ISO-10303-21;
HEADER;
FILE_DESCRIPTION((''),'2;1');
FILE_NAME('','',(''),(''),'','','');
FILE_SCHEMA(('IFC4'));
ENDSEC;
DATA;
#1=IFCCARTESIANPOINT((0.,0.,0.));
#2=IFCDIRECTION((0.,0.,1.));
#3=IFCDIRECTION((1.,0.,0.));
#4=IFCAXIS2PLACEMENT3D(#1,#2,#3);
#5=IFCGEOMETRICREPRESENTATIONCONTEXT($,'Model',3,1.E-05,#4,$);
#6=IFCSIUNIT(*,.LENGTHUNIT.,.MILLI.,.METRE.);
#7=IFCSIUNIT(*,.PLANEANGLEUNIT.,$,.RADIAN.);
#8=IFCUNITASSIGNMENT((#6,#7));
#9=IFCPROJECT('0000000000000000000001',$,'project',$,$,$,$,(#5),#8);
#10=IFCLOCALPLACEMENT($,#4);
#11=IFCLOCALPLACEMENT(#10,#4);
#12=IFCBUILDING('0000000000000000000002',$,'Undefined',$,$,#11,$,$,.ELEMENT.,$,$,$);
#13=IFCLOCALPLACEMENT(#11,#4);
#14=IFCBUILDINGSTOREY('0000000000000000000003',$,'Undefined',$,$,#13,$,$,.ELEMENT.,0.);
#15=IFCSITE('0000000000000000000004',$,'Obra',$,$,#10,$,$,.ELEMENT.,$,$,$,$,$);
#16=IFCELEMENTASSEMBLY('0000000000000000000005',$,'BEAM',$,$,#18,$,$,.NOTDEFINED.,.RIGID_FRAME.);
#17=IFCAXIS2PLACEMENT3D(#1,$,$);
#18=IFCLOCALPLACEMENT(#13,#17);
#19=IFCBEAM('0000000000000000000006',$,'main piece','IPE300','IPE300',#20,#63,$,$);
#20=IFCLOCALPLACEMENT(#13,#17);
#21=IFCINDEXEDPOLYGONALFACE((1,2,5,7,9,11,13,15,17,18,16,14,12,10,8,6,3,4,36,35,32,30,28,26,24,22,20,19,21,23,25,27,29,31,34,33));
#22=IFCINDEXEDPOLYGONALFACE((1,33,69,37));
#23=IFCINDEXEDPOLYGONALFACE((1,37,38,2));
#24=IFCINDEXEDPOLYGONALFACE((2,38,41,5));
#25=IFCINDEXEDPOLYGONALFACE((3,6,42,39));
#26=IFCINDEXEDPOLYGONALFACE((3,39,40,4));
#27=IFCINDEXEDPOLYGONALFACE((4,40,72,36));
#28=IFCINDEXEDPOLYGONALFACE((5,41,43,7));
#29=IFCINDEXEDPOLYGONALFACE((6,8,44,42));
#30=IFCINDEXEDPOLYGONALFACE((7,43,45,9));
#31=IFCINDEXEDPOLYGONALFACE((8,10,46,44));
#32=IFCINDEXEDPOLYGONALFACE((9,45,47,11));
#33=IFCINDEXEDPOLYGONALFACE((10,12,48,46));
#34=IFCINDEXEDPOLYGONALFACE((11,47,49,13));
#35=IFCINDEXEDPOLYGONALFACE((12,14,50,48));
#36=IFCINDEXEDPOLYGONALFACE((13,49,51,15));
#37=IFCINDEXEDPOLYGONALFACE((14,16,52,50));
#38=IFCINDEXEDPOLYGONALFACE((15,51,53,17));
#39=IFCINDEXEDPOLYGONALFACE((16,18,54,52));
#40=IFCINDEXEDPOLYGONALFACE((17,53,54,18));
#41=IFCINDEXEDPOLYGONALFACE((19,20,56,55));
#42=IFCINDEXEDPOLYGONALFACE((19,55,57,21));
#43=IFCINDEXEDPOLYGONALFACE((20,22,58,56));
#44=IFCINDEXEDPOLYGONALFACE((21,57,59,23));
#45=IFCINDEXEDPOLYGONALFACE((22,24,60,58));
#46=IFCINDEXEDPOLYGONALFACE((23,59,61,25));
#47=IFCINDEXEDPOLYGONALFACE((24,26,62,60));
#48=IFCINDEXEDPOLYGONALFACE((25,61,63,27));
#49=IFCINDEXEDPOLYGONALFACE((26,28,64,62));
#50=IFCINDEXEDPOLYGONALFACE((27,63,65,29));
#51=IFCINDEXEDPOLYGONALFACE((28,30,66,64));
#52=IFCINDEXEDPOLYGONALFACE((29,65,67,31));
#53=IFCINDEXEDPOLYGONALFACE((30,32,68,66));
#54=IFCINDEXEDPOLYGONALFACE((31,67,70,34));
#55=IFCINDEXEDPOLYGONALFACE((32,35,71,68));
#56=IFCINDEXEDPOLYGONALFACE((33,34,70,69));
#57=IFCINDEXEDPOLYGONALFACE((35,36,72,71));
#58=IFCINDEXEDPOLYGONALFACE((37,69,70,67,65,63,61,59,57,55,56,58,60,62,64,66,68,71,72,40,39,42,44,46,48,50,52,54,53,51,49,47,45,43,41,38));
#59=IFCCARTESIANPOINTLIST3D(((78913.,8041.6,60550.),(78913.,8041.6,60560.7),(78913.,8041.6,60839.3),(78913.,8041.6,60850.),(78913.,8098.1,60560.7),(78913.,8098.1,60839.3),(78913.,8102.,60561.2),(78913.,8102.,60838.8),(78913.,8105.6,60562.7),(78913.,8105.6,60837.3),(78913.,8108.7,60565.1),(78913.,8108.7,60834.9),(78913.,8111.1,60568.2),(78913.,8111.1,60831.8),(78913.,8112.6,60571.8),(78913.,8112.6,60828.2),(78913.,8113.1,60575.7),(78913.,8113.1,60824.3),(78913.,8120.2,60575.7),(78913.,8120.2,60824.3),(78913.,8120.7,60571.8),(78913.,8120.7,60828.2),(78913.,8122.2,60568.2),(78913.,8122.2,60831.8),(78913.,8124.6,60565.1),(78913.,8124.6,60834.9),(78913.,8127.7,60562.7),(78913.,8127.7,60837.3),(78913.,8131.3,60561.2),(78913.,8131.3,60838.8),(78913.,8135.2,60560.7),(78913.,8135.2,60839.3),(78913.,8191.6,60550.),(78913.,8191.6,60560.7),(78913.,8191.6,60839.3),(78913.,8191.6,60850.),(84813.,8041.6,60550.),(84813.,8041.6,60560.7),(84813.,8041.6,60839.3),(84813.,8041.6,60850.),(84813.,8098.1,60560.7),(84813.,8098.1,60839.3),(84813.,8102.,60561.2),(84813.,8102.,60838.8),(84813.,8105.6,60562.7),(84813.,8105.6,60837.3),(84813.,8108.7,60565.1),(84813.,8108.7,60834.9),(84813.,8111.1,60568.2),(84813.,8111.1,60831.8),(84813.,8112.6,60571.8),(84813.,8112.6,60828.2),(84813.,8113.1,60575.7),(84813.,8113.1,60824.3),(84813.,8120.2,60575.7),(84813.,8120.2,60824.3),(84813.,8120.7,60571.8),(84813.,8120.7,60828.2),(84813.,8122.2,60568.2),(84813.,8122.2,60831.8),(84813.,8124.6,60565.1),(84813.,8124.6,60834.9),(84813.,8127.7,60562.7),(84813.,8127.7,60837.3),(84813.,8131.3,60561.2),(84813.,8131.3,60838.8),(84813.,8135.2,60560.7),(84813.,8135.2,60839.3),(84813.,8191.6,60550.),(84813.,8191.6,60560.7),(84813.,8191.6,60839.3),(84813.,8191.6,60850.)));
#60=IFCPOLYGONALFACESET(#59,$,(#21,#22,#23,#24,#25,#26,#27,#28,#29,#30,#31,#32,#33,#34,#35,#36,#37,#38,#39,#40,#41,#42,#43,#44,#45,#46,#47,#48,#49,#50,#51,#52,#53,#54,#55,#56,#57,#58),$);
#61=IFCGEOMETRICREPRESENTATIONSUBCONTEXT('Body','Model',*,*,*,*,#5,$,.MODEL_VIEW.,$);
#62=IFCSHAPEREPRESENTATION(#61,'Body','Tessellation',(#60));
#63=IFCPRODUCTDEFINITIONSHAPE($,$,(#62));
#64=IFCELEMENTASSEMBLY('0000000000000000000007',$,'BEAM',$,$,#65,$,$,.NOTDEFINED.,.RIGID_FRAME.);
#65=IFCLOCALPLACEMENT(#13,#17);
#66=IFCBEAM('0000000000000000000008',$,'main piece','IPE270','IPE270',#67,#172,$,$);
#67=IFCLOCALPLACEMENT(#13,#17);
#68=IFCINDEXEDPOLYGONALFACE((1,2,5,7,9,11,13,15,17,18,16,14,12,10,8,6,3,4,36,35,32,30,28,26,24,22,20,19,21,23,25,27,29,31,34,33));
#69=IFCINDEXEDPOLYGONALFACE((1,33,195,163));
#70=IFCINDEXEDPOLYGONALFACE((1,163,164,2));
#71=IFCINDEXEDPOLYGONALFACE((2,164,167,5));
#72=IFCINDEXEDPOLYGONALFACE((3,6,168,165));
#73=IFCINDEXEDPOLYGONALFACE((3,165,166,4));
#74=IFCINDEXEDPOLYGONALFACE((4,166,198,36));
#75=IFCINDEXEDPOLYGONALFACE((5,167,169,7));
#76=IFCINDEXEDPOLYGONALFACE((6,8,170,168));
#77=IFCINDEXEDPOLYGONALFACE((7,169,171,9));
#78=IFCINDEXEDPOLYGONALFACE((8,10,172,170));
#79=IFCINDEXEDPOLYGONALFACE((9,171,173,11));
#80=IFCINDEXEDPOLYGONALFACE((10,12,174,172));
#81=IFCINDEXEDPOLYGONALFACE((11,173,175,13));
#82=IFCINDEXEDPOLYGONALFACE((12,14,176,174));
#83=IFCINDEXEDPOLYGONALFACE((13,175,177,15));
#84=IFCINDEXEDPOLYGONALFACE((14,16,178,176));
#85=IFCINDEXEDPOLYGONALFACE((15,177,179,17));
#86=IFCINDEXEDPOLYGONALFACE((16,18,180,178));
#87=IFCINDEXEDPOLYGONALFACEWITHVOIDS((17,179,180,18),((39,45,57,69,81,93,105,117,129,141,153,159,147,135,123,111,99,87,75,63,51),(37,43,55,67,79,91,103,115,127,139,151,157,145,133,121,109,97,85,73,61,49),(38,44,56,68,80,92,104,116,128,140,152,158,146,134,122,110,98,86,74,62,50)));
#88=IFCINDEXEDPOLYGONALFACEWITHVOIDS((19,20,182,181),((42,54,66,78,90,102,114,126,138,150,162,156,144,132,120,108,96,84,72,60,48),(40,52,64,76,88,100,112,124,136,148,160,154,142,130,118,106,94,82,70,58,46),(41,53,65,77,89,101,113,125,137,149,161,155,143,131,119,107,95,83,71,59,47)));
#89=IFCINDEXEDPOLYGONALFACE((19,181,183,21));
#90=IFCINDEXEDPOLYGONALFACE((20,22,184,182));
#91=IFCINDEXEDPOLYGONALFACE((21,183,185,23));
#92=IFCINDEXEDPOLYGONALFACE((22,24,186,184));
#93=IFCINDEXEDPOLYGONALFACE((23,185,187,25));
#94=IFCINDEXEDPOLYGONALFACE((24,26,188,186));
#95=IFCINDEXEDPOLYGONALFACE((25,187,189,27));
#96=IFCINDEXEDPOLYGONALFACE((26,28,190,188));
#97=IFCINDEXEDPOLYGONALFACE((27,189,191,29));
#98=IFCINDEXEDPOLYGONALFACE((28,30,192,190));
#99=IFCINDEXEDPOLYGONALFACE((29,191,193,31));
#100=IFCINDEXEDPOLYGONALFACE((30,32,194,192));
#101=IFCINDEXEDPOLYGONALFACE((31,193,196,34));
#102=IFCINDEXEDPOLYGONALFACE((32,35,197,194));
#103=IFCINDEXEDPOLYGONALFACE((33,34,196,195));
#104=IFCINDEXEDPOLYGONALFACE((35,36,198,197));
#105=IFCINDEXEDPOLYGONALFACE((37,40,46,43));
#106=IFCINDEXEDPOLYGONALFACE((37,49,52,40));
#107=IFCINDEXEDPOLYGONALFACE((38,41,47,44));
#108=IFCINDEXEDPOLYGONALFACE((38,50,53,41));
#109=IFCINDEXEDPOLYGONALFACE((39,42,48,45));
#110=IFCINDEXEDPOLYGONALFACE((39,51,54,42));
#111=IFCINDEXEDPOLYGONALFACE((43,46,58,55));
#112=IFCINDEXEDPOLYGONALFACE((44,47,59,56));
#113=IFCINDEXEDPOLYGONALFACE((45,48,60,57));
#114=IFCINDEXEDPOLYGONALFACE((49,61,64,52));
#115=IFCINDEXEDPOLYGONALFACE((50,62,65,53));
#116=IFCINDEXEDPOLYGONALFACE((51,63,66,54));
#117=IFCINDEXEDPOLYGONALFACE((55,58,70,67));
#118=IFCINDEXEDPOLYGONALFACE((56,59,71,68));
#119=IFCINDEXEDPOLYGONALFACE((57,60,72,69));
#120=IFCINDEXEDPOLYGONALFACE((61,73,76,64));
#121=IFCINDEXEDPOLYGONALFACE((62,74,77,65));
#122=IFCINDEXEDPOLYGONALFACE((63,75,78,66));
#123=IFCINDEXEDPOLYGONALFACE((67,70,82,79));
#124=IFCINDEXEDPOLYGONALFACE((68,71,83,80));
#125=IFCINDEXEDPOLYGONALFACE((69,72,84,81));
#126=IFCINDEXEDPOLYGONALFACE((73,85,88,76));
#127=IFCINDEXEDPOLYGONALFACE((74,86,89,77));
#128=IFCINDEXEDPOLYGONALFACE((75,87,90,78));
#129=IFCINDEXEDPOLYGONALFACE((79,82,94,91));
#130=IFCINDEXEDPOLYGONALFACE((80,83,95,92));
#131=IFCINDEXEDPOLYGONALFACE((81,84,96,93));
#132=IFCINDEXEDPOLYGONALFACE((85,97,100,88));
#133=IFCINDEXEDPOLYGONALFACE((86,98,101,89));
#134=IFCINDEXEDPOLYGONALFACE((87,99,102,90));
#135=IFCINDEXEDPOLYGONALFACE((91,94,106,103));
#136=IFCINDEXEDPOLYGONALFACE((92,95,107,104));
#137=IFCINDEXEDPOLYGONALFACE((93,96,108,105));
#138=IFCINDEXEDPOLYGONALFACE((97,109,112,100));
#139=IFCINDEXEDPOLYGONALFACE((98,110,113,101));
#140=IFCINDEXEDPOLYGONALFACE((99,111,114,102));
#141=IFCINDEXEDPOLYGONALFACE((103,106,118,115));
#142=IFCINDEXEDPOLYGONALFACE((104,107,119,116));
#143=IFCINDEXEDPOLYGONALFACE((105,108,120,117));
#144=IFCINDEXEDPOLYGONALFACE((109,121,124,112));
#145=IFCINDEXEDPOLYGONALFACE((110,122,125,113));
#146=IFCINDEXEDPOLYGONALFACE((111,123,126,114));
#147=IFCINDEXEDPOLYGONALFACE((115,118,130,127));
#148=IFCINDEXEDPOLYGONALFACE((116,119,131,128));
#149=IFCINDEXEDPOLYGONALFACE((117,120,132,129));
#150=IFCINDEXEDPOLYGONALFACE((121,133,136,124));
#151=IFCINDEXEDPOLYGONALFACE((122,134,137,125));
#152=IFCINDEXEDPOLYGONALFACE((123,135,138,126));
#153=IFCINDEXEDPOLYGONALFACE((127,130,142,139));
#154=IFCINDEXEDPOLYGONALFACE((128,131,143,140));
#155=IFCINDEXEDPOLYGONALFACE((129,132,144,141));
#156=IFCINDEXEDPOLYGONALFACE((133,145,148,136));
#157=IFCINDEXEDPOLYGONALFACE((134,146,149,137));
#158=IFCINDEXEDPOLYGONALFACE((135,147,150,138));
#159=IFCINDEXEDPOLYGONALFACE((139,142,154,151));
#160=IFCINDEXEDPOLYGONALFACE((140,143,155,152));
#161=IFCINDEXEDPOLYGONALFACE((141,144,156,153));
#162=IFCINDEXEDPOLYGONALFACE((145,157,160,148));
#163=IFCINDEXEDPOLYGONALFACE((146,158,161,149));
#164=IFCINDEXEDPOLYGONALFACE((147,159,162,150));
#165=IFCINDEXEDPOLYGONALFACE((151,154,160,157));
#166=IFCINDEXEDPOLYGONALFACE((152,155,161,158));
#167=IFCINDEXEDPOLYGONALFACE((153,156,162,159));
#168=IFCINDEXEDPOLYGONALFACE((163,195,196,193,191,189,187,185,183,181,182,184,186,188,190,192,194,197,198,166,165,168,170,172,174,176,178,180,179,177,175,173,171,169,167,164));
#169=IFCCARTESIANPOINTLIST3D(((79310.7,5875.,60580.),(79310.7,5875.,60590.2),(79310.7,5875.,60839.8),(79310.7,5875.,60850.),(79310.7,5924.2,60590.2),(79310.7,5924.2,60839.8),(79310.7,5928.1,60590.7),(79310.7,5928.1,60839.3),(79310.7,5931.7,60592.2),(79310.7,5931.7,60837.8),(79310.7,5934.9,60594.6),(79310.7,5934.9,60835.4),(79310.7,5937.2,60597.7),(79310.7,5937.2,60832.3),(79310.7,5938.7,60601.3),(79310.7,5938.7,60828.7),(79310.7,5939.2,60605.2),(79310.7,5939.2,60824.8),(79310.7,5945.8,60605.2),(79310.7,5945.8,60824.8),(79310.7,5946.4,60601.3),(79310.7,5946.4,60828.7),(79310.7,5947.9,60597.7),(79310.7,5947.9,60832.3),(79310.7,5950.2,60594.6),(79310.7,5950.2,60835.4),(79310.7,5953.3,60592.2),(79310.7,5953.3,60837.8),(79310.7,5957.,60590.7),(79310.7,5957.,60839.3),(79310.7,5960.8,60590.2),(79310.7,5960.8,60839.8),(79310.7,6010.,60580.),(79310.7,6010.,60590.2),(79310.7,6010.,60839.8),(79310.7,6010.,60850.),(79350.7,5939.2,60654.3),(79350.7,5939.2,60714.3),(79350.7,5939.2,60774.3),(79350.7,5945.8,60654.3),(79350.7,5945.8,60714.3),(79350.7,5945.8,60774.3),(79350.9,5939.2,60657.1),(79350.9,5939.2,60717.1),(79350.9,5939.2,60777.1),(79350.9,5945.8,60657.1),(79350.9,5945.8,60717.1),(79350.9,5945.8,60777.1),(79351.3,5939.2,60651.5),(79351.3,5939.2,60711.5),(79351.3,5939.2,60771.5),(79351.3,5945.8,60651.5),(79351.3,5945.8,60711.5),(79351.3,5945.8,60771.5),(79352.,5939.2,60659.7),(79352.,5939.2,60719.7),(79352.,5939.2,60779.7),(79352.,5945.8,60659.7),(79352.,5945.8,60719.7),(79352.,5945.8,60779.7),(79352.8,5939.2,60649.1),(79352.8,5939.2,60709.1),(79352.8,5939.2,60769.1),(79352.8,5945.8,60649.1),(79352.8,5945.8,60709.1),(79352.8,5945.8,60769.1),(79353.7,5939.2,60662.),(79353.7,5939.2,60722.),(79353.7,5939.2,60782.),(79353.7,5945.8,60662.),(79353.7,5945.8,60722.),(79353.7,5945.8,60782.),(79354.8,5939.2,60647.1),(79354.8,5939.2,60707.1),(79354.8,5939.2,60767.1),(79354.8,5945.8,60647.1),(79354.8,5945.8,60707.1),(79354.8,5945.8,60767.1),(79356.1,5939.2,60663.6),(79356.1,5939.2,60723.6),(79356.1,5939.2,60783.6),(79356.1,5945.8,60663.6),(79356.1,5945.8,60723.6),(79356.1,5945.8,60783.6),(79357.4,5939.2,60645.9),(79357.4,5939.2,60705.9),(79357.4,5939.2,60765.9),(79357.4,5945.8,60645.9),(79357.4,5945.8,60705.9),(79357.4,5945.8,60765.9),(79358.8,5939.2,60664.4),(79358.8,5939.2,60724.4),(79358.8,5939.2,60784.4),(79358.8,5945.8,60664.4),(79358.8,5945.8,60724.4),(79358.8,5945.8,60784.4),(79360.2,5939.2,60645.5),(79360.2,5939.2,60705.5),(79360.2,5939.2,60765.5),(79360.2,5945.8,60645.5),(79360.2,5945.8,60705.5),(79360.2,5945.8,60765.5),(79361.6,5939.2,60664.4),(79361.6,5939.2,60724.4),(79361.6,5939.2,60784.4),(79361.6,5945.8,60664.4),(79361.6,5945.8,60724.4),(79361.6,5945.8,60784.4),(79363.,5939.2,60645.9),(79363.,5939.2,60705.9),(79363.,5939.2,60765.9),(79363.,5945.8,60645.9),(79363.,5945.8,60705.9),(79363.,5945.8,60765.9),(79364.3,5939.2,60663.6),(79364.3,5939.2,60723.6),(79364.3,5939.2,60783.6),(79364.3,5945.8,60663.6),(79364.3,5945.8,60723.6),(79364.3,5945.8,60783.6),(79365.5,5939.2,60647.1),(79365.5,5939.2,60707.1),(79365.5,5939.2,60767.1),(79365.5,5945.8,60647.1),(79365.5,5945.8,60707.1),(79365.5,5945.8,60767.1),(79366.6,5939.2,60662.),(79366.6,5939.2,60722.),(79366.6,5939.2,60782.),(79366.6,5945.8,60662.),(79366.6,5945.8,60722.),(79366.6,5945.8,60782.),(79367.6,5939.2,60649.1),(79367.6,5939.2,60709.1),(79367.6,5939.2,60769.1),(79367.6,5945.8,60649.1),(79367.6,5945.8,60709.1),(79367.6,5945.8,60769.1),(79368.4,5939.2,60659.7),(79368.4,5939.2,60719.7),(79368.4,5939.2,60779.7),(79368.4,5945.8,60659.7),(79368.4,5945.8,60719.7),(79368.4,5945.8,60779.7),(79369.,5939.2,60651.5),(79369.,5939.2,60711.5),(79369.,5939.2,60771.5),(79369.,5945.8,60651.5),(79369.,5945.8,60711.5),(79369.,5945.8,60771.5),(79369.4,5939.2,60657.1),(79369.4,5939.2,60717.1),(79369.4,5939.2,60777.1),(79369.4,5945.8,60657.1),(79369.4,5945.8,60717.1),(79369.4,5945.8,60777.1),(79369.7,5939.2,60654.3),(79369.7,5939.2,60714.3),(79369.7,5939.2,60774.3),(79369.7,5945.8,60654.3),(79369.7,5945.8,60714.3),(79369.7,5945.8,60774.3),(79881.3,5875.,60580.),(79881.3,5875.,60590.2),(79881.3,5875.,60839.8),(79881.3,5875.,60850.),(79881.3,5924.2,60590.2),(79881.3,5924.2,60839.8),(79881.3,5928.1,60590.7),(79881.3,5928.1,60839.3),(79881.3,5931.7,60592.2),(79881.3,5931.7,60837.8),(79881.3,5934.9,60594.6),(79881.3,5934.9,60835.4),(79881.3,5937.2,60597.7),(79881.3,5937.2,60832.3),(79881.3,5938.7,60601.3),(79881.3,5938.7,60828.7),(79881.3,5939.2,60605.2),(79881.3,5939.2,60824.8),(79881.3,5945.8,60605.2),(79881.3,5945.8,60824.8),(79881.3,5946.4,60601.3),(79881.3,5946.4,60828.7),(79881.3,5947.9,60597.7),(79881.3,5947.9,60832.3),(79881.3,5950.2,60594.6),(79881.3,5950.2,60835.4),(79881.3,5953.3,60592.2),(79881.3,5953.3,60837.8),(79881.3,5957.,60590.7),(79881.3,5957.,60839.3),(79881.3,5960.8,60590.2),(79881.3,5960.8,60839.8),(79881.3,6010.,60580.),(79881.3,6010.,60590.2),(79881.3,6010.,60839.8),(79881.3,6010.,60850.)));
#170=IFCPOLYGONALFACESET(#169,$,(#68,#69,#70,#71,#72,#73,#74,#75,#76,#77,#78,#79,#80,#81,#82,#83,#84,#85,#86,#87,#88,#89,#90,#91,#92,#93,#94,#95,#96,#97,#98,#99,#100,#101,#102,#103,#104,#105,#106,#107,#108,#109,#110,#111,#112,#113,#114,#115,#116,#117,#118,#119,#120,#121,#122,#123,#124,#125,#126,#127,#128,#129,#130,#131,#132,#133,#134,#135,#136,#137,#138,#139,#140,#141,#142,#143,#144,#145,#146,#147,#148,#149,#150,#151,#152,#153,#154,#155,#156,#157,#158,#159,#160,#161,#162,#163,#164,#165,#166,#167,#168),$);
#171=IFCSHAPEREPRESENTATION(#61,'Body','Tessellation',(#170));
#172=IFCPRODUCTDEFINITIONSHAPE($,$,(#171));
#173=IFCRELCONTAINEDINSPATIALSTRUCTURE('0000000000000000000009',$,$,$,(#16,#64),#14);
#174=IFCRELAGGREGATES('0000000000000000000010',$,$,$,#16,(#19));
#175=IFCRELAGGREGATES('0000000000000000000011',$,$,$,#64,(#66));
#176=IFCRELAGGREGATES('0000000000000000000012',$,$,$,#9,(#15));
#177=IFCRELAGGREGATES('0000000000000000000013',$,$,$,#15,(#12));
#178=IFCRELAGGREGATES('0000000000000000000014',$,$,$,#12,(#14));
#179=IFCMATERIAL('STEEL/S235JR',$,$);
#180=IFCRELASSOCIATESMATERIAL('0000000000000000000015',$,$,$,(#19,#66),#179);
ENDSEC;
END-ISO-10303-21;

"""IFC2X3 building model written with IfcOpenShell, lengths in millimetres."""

from ifc_helpers import new_model, si_unit, frame, origin_with_axes, origin_2d_with_axis, place, context, subcontext, project, spatial, circle, i_section, extrude, clip, halfspace, source, transform, mapped, material, element, aggregate, save


model = new_model("IFC2X3")

# Units and contexts
model_context = context("Model", 3, precision=1e-05, world=origin_with_axes())
body_context = subcontext(model_context, "Body", "Model", "MODEL_VIEW")
ifc_project = project(units=[si_unit("LENGTHUNIT", "METRE", prefix="MILLI"), si_unit("PLANEANGLEUNIT", "RADIAN")], contexts=[model_context])

# Site, building, storey
site_placement = place(None, origin_with_axes())
site = spatial("IfcSite", under=ifc_project, at=site_placement, Name="Obra", CompositionType="ELEMENT")
building_placement = place(site_placement, origin_with_axes())
building = spatial("IfcBuilding", under=site, at=building_placement, Name="Undefined", CompositionType="ELEMENT")
storey_placement = place(building_placement, origin_with_axes())
storey = spatial("IfcBuildingStorey", under=building, at=storey_placement, Name="Undefined", CompositionType="ELEMENT", Elevation=0.0)

# Shared definitions
ifc_material_1 = material(Name="STEEL/S235JR")

# Element assembly, beam
assembly_1_placement = place(storey_placement, origin_with_axes())
assembly_1 = element("IfcElementAssembly", 1, at=assembly_1_placement, inside=storey, Name="BEAM", AssemblyPlace="NOTDEFINED", PredefinedType="RIGID_FRAME")
beam_1_placement = place(assembly_1_placement, frame((78913.0, 8116.6, 60700.0), z_axis=(0.0, 0.0, 1.0), x_axis=(1.0, 0.0, 0.0)))
beam_1 = element("IfcBeam", 2, at=beam_1_placement, material=ifc_material_1, Name="main piece", Description="IPE300", ObjectType="IPE300", context=body_context, shape_type="SweptSolid", body=[
    extrude(i_section(OverallWidth=150.0, OverallDepth=300.0, WebThickness=7.1, FlangeThickness=10.7, FilletRadius=15.0, at=origin_2d_with_axis()), frame((5900.0, 0.0, 0.0), z_axis=(-1.0, 0.0, 0.0), x_axis=(0.0, -1.0, 0.0)), (0.0, 0.0, 1.0), 5900.0),
])
aggregate(assembly_1, [beam_1])

# Element assembly, beam, opening
assembly_2_placement = place(storey_placement, origin_with_axes())
assembly_2 = element("IfcElementAssembly", 3, at=assembly_2_placement, inside=storey, Name="BEAM", AssemblyPlace="NOTDEFINED", PredefinedType="RIGID_FRAME")
beam_2_placement = place(assembly_2_placement, frame((78913.0, 5942.5, 60715.0), z_axis=(0.0, 0.0, 1.0), x_axis=(1.0, 0.0, 0.0)))
beam_2 = element("IfcBeam", 4, at=beam_2_placement, material=ifc_material_1, Name="main piece", Description="IPE270", ObjectType="IPE270", context=body_context, shape_type="Clipping", body=[
    clip(extrude(i_section(OverallWidth=135.0, OverallDepth=270.0, WebThickness=6.6, FlangeThickness=10.2, FilletRadius=15.0, at=origin_2d_with_axis()), frame((968.3, 0.0, 0.0), z_axis=(-1.0, 0.0, 0.0), x_axis=(0.0, -1.0, 0.0)), (0.0, 0.0, 1.0), 968.3), halfspace(frame((397.6, 60.0, -120.0), z_axis=(-1.0, -0.000019, 0.0), x_axis=(0.0, 0.0, 1.0)), False)),
])
shared_shape_1 = source(origin_with_axes(), body_context, "Body", "SweptSolid", [
    extrude(circle(Radius=9.5, at=origin_2d_with_axis()), frame((0.0, -3.4, 0.0), z_axis=(0.0, 1.0, 0.0), x_axis=(1.0, 0.0, 0.0)), (0.0, 0.0, 1.0), 6.8),
])
opening_1_placement = place(assembly_2_placement, frame((79310.2, 5942.5, 60835.0), z_axis=(1.0, 0.0, 0.0), x_axis=(0.0, 0.0, -1.0)))
element("IfcOpeningElement", 5, at=opening_1_placement, cuts=beam_2, ObjectType="Opening", context=body_context, shape_type="MappedRepresentation", body=[
    mapped(shared_shape_1, transform((60.0, 0.0, 50.0))),
    mapped(shared_shape_1, transform((120.0, 0.0, 50.0))),
    mapped(shared_shape_1, transform((180.0, 0.0, 50.0))),
])
aggregate(assembly_2, [beam_2])

save(model, "model.ifc")
